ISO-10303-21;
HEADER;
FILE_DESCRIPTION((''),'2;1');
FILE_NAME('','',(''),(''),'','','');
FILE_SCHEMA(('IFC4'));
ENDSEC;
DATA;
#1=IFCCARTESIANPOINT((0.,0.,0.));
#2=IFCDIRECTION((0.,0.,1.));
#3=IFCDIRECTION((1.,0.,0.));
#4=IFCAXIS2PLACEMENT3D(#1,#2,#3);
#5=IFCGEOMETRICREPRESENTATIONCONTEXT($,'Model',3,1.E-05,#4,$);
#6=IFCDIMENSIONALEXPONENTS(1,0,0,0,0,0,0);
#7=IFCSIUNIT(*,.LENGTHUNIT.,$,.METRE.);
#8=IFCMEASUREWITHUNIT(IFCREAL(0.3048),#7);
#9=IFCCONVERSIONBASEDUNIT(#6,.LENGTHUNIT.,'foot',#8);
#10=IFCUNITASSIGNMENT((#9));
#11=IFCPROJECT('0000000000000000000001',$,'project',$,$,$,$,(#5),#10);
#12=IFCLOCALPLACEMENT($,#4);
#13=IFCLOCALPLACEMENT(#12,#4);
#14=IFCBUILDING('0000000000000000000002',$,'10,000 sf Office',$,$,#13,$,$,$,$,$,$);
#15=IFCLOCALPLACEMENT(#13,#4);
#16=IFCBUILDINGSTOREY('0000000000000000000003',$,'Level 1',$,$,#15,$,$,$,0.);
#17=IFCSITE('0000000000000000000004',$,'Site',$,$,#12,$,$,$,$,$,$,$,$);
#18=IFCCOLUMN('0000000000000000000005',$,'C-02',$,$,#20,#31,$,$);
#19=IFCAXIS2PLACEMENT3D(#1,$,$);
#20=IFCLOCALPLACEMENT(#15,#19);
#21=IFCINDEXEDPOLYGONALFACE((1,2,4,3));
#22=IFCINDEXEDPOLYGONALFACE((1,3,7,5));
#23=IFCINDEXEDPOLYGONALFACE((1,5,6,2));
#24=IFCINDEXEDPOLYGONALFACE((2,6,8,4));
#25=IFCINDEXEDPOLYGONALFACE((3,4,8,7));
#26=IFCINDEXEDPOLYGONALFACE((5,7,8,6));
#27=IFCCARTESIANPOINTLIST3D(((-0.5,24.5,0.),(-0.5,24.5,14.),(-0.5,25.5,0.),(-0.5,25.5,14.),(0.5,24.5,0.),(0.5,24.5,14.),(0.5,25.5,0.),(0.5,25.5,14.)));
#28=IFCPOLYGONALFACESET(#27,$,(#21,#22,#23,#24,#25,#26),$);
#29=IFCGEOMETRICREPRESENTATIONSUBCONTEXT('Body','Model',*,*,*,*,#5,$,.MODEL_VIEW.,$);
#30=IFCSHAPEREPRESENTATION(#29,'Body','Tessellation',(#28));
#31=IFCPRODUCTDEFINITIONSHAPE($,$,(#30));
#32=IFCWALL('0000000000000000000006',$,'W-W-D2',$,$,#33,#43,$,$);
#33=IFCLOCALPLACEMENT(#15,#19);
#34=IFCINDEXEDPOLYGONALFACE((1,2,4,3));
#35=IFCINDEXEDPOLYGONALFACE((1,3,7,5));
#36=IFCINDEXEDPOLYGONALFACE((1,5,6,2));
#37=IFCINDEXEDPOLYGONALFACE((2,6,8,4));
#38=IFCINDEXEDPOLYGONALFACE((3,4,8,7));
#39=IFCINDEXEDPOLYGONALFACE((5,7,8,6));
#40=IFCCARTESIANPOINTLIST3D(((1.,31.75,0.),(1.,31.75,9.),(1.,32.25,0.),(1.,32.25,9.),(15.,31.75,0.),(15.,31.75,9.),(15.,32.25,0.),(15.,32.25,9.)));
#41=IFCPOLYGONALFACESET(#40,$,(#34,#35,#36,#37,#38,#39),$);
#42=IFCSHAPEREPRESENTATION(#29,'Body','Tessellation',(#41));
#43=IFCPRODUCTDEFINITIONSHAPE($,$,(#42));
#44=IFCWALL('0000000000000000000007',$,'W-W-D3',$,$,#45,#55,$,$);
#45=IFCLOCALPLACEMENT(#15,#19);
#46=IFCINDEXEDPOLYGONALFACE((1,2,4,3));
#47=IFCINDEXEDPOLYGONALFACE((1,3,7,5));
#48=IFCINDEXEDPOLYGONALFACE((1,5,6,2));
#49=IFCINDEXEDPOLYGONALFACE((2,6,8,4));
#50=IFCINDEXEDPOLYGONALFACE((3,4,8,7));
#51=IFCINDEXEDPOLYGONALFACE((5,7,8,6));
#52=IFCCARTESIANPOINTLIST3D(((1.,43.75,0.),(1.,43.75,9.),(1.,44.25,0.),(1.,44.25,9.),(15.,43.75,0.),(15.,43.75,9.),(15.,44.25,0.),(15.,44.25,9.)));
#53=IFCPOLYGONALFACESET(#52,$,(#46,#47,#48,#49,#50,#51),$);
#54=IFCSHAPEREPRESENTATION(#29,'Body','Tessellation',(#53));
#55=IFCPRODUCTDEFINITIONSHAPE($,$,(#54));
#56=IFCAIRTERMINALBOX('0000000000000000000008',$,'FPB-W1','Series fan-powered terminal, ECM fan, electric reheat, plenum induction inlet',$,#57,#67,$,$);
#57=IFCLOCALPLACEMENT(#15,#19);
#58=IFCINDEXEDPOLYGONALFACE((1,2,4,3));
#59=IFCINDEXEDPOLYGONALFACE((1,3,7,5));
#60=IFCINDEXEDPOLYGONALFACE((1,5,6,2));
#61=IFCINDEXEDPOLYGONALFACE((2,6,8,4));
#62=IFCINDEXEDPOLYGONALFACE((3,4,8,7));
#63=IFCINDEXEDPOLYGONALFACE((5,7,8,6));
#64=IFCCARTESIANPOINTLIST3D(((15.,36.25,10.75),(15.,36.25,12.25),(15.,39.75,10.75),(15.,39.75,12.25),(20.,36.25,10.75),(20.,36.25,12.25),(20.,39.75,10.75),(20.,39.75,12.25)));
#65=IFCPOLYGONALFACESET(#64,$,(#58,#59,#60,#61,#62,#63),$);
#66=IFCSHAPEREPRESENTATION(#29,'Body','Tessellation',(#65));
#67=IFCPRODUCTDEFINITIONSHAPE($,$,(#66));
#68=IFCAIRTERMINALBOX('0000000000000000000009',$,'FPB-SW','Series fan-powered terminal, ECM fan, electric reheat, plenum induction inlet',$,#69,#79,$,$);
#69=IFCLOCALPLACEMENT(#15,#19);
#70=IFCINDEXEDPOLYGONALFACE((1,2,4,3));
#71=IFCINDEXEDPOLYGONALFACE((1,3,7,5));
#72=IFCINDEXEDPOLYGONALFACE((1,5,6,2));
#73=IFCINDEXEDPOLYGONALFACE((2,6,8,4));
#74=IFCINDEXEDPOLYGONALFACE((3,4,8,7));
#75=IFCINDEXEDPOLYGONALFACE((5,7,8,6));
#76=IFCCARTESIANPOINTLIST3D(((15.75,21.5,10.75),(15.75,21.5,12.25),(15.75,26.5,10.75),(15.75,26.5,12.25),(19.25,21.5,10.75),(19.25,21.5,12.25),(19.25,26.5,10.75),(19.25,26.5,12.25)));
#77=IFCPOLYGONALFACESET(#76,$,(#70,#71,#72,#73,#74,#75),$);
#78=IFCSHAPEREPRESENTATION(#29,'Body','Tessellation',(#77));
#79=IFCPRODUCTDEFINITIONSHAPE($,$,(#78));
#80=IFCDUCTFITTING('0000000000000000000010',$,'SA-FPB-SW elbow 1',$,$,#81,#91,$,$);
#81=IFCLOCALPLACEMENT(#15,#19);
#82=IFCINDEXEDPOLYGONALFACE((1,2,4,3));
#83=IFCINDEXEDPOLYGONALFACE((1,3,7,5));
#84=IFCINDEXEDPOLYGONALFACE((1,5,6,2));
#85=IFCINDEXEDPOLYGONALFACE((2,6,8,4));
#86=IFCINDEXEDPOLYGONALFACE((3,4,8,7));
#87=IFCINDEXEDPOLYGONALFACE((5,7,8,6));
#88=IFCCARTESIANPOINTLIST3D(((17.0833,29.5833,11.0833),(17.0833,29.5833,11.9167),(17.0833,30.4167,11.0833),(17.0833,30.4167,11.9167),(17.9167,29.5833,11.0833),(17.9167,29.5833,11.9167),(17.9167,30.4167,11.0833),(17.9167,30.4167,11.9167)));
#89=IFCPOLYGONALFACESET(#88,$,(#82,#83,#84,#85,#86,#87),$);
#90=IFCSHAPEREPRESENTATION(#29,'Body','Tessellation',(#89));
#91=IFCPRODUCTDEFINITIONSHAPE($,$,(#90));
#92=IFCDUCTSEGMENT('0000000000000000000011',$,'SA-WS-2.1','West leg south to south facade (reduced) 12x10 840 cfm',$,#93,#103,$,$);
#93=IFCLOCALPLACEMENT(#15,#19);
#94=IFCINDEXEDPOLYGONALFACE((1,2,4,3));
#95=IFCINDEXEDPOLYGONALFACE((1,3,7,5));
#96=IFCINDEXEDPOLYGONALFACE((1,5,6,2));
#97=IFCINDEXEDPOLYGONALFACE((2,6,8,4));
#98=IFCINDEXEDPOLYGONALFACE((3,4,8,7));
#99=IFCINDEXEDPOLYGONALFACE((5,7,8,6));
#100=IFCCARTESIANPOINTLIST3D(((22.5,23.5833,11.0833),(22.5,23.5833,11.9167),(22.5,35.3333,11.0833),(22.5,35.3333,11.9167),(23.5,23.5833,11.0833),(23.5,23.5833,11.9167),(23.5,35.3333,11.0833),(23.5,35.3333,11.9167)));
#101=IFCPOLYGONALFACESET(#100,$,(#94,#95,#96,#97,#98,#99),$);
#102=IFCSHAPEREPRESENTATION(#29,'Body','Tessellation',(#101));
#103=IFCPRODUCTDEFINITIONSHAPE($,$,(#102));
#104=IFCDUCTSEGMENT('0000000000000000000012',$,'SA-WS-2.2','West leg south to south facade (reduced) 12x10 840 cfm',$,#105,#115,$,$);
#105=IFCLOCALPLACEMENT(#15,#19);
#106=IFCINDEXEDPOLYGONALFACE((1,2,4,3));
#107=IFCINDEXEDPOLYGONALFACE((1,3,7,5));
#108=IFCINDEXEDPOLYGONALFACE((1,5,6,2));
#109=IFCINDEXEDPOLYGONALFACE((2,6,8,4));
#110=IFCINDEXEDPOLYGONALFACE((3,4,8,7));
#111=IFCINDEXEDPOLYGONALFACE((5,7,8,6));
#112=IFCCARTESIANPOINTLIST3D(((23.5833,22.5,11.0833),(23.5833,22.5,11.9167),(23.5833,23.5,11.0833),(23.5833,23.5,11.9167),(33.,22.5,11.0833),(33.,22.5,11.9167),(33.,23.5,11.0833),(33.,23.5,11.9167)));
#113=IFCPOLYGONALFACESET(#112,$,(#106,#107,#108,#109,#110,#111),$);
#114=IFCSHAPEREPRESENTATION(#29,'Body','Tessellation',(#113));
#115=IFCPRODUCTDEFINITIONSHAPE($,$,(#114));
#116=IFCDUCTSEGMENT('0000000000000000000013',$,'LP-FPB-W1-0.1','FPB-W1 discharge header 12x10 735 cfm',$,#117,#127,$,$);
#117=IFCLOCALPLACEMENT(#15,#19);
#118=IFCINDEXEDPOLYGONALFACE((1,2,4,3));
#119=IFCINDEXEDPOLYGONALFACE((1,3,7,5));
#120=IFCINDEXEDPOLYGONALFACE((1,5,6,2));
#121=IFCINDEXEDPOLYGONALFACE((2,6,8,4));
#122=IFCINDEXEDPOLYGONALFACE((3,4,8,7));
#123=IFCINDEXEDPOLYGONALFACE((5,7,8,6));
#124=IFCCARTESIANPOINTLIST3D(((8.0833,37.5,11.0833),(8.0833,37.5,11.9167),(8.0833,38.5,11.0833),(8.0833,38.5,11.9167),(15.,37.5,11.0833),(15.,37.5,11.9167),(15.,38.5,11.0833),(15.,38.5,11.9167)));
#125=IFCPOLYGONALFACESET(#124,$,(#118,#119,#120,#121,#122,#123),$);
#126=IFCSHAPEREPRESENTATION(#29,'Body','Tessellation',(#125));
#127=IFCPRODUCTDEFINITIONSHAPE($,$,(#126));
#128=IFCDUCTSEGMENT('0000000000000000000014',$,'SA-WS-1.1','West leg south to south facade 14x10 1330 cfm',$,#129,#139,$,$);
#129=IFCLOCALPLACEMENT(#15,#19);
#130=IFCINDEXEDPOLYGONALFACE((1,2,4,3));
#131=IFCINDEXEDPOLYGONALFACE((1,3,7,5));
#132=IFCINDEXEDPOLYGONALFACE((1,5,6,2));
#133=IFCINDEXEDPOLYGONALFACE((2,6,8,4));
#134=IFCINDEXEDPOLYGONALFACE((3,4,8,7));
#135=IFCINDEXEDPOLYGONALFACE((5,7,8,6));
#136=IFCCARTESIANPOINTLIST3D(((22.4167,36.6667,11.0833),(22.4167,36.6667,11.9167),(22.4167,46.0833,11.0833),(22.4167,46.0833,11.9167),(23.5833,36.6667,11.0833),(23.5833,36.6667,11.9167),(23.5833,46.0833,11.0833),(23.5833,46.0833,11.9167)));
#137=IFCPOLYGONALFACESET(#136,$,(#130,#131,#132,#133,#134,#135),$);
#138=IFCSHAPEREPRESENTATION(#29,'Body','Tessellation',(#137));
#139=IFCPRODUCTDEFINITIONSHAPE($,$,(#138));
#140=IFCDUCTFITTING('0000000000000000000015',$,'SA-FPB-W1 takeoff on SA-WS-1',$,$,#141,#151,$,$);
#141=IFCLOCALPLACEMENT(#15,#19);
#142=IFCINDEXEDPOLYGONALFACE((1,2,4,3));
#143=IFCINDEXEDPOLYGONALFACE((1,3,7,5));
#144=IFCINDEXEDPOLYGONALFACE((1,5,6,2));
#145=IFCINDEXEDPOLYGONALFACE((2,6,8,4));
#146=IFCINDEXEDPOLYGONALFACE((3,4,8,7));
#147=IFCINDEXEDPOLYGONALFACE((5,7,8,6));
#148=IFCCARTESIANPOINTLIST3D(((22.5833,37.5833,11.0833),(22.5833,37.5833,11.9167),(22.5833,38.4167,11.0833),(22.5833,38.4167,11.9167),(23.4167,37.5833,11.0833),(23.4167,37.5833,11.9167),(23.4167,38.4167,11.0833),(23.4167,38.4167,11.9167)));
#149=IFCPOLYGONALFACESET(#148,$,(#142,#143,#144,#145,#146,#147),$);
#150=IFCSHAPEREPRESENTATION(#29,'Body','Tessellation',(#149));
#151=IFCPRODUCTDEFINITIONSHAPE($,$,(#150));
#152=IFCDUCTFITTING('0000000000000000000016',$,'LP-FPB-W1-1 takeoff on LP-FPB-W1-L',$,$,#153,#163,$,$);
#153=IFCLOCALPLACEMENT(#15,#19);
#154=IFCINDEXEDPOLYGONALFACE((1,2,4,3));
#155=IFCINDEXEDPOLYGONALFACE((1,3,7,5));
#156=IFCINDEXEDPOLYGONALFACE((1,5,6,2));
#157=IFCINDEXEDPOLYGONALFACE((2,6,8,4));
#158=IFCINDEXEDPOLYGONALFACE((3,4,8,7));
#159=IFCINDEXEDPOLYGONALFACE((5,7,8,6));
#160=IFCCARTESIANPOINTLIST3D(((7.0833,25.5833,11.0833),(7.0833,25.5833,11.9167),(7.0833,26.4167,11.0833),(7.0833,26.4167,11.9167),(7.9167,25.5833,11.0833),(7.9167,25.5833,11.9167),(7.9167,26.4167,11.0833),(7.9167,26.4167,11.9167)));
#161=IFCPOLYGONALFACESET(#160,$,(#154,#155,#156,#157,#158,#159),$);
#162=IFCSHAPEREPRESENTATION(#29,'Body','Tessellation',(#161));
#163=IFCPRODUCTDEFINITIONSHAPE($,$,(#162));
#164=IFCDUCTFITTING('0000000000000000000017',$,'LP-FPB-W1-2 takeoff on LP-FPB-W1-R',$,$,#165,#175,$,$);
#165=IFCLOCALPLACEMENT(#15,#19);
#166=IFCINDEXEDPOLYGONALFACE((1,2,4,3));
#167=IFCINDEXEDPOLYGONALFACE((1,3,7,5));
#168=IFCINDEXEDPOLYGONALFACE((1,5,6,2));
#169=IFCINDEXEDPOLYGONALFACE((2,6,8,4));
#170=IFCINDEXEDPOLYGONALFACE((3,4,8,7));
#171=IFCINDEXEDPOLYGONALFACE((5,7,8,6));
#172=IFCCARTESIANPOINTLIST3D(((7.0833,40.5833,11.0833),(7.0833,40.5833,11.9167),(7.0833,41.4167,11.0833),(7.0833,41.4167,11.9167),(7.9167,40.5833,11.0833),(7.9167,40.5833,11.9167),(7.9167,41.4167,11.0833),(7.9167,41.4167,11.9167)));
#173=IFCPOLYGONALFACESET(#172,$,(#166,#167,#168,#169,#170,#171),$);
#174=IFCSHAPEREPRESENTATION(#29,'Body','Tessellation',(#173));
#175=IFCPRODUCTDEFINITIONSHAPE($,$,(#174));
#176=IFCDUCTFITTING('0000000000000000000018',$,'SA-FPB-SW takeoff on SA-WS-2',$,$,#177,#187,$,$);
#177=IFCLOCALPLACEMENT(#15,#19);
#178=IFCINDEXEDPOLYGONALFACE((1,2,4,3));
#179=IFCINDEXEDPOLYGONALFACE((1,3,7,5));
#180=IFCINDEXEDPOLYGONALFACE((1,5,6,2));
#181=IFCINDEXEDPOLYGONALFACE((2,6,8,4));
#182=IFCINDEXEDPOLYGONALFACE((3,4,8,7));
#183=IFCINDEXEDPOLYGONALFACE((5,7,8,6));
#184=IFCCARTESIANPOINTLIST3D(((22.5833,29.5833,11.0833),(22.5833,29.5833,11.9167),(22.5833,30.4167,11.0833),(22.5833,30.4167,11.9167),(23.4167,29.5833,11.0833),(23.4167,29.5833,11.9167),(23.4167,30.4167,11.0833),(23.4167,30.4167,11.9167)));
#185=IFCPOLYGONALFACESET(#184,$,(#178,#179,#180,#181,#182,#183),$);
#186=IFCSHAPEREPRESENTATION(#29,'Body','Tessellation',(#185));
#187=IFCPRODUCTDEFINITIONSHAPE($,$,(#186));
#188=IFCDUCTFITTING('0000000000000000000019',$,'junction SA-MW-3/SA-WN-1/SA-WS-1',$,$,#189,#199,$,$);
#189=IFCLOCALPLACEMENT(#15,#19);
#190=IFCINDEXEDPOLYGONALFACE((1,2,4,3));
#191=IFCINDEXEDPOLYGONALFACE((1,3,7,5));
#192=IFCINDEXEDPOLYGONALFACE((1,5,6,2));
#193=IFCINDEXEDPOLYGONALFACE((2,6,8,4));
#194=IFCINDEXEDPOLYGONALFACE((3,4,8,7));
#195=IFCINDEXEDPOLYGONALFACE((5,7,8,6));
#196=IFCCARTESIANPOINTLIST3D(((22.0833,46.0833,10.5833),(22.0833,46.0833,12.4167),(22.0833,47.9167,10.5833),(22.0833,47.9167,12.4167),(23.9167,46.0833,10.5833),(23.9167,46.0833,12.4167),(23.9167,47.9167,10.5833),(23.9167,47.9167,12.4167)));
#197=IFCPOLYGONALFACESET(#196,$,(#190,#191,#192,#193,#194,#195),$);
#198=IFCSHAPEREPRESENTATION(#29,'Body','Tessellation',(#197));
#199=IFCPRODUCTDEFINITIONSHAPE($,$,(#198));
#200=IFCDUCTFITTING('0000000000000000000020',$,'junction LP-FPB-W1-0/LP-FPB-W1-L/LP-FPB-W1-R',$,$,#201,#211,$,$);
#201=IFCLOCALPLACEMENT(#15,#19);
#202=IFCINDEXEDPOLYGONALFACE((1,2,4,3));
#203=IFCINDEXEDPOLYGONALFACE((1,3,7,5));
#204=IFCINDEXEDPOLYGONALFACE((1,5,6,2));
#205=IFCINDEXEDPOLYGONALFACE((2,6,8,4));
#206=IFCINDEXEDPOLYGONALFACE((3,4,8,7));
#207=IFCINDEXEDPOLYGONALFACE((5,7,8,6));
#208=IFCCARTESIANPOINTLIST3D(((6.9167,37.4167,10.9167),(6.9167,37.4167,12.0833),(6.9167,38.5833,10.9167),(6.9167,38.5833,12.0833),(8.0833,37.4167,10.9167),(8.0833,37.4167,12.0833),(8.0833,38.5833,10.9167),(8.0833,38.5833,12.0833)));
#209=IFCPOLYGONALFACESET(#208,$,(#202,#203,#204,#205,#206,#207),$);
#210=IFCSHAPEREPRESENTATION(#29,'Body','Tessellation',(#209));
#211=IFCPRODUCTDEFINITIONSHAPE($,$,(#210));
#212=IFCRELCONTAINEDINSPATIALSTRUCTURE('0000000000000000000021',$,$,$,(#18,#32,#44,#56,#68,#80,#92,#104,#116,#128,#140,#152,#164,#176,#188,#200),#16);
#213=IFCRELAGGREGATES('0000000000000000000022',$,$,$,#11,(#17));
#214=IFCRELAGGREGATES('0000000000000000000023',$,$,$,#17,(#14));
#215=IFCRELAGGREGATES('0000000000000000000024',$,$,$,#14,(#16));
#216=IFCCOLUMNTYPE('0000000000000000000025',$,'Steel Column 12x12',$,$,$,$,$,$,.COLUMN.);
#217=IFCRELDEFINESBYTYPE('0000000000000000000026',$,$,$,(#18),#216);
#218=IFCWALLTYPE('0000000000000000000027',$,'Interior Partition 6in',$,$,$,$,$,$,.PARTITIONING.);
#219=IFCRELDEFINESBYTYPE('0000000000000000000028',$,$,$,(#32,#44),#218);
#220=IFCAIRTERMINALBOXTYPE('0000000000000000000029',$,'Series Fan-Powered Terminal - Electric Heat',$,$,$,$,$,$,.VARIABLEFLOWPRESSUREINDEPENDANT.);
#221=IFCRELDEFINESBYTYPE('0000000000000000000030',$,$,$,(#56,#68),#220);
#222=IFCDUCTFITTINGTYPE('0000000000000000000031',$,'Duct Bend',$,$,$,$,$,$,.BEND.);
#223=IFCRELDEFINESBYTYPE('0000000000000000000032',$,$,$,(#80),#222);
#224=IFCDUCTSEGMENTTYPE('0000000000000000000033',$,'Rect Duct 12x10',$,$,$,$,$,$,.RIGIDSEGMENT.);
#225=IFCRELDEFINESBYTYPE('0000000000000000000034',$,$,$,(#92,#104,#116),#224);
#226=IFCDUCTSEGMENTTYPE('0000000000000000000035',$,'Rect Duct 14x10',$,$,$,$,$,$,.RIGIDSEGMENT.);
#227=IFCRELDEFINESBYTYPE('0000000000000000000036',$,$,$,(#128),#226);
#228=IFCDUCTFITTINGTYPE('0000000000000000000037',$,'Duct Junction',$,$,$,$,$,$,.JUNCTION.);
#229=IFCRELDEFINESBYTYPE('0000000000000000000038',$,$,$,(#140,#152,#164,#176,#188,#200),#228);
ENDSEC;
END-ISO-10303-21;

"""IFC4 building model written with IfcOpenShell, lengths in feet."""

from ifc_helpers import new_model, entity, si_unit, converted_unit, frame, origin_with_axes, place, context, subcontext, project, spatial, rectangle, extrude, type_object, element, save


model = new_model("IFC4")

# Units and contexts
model_context = context("Model", 3, precision=1e-05, world=origin_with_axes())
body_context = subcontext(model_context, "Body", "Model", "MODEL_VIEW")
ifc_project = project(units=[converted_unit("LENGTHUNIT", "foot", entity("IfcReal", 0.3048), si_unit("LENGTHUNIT", "METRE"), dimensions=[1, 0, 0, 0, 0, 0, 0])], contexts=[model_context])

# Site, building, storey
site_placement = place(None, origin_with_axes())
site = spatial("IfcSite", under=ifc_project, at=site_placement, Name="Site")
building_placement = place(site_placement, origin_with_axes())
building = spatial("IfcBuilding", under=site, at=building_placement, Name="10,000 sf Office")
storey_placement = place(building_placement, origin_with_axes())
storey = spatial("IfcBuildingStorey", under=building, at=storey_placement, Name="Level 1", Elevation=0.0)

# Column
column_type = type_object("IfcColumnType", Name="Steel Column 12x12", PredefinedType="COLUMN")
column_placement = place(storey_placement, frame((0.0, 25.0, 0.0), z_axis=(0.0, 0.0, 1.0), x_axis=(1.0, 0.0, 0.0)))
element("IfcColumn", 1, at=column_placement, inside=storey, type_object=column_type, Name="C-02", context=body_context, shape_type="SweptSolid", body=[
    extrude(rectangle(XDim=1.0, YDim=1.0), None, (0.0, 0.0, 1.0), 14.0),
])

# Walls
wall_type = type_object("IfcWallType", Name="Interior Partition 6in", PredefinedType="PARTITIONING")
for number, where, z_axis, x_axis, name in (
    (2, (8.0, 32.0, 0.0), (0.0, 0.0, 1.0), (1.0, 0.0, 0.0), "W-W-D2"),
    (3, (8.0, 44.0, 0.0), (0.0, 0.0, 1.0), (1.0, 0.0, 0.0), "W-W-D3"),
):
    element("IfcWall", number, at=place(storey_placement, frame(where, z_axis=z_axis, x_axis=x_axis)), inside=storey, type_object=wall_type, Name=name, context=body_context, shape_type="SweptSolid", body=[
        extrude(rectangle(XDim=14.0, YDim=0.5), None, (0.0, 0.0, 1.0), 9.0),
    ])

# Air terminal boxes
air_terminal_box_type = type_object("IfcAirTerminalBoxType", Name="Series Fan-Powered Terminal - Electric Heat", PredefinedType="VARIABLEFLOWPRESSUREINDEPENDANT")
for number, where, z_axis, x_axis, name in (
    (4, (17.5, 38.0, 10.75), (0.0, 0.0, 1.0), (-1.0, 0.0, 0.0), "FPB-W1"),
    (5, (17.5, 24.0, 10.75), (0.0, 0.0, 1.0), (0.0, -1.0, 0.0), "FPB-SW"),
):
    element("IfcAirTerminalBox", number, at=place(storey_placement, frame(where, z_axis=z_axis, x_axis=x_axis)), inside=storey, type_object=air_terminal_box_type, Name=name, Description="Series fan-powered terminal, ECM fan, electric reheat, plenum induction inlet", context=body_context, shape_type="SweptSolid", body=[
        extrude(rectangle(XDim=5.0, YDim=3.5), None, (0.0, 0.0, 1.0), 1.5),
    ])

# Duct fitting
duct_fitting_type_1 = type_object("IfcDuctFittingType", Name="Duct Bend", PredefinedType="BEND")
duct_fitting_1_placement = place(storey_placement, frame((17.5, 30.0, 11.0833), z_axis=(0.0, 0.0, 1.0), x_axis=(1.0, 0.0, 0.0)))
element("IfcDuctFitting", 6, at=duct_fitting_1_placement, inside=storey, type_object=duct_fitting_type_1, Name="SA-FPB-SW elbow 1", context=body_context, shape_type="SweptSolid", body=[
    extrude(rectangle(XDim=0.8333, YDim=0.8333), None, (0.0, 0.0, 1.0), 0.8333),
])

# Duct segments
duct_segment_type_1 = type_object("IfcDuctSegmentType", Name="Rect Duct 12x10", PredefinedType="RIGIDSEGMENT")
duct_segment_1_placement = place(storey_placement, frame((23.0, 35.3333, 11.5), z_axis=(0.0, -1.0, 0.0), x_axis=(1.0, 0.0, 0.0)))
element("IfcDuctSegment", 7, at=duct_segment_1_placement, inside=storey, type_object=duct_segment_type_1, Name="SA-WS-2.1", Description="West leg south to south facade (reduced) 12x10 840 cfm", context=body_context, shape_type="SweptSolid", body=[
    extrude(rectangle(XDim=1.0, YDim=0.8333), None, (0.0, 0.0, 1.0), 11.75),
])
duct_segment_2_placement = place(storey_placement, frame((23.5833, 23.0, 11.5), z_axis=(1.0, 0.0, 0.0), x_axis=(0.0, 1.0, 0.0)))
element("IfcDuctSegment", 8, at=duct_segment_2_placement, inside=storey, type_object=duct_segment_type_1, Name="SA-WS-2.2", Description="West leg south to south facade (reduced) 12x10 840 cfm", context=body_context, shape_type="SweptSolid", body=[
    extrude(rectangle(XDim=1.0, YDim=0.8333), None, (0.0, 0.0, 1.0), 9.4167),
])
duct_segment_3_placement = place(storey_placement, frame((15.0, 38.0, 11.5), z_axis=(-1.0, 0.0, 0.0), x_axis=(0.0, -1.0, 0.0)))
element("IfcDuctSegment", 9, at=duct_segment_3_placement, inside=storey, type_object=duct_segment_type_1, Name="LP-FPB-W1-0.1", Description="FPB-W1 discharge header 12x10 735 cfm", context=body_context, shape_type="SweptSolid", body=[
    extrude(rectangle(XDim=1.0, YDim=0.8333), None, (0.0, 0.0, 1.0), 6.9167),
])
duct_segment_type_2 = type_object("IfcDuctSegmentType", Name="Rect Duct 14x10", PredefinedType="RIGIDSEGMENT")
duct_segment_4_placement = place(storey_placement, frame((23.0, 46.0833, 11.5), z_axis=(0.0, -1.0, 0.0), x_axis=(1.0, 0.0, 0.0)))
element("IfcDuctSegment", 10, at=duct_segment_4_placement, inside=storey, type_object=duct_segment_type_2, Name="SA-WS-1.1", Description="West leg south to south facade 14x10 1330 cfm", context=body_context, shape_type="SweptSolid", body=[
    extrude(rectangle(XDim=1.1667, YDim=0.8333), None, (0.0, 0.0, 1.0), 9.4167),
])

# Duct fittings
duct_fitting_type_2 = type_object("IfcDuctFittingType", Name="Duct Junction", PredefinedType="JUNCTION")
for number, where, z_axis, x_axis, name in (
    (11, (23.0, 38.0, 11.0833), (0.0, 0.0, 1.0), (1.0, 0.0, 0.0), "SA-FPB-W1 takeoff on SA-WS-1"),
    (12, (7.5, 26.0, 11.0833), (0.0, 0.0, 1.0), (1.0, 0.0, 0.0), "LP-FPB-W1-1 takeoff on LP-FPB-W1-L"),
    (13, (7.5, 41.0, 11.0833), (0.0, 0.0, 1.0), (1.0, 0.0, 0.0), "LP-FPB-W1-2 takeoff on LP-FPB-W1-R"),
    (14, (23.0, 30.0, 11.0833), (0.0, 0.0, 1.0), (1.0, 0.0, 0.0), "SA-FPB-SW takeoff on SA-WS-2"),
):
    element("IfcDuctFitting", number, at=place(storey_placement, frame(where, z_axis=z_axis, x_axis=x_axis)), inside=storey, type_object=duct_fitting_type_2, Name=name, context=body_context, shape_type="SweptSolid", body=[
        extrude(rectangle(XDim=0.8333, YDim=0.8333), None, (0.0, 0.0, 1.0), 0.8333),
    ])
duct_fitting_2_placement = place(storey_placement, frame((23.0, 47.0, 10.5833), z_axis=(0.0, 0.0, 1.0), x_axis=(1.0, 0.0, 0.0)))
element("IfcDuctFitting", 15, at=duct_fitting_2_placement, inside=storey, type_object=duct_fitting_type_2, Name="junction SA-MW-3/SA-WN-1/SA-WS-1", context=body_context, shape_type="SweptSolid", body=[
    extrude(rectangle(XDim=1.8333, YDim=1.8333), None, (0.0, 0.0, 1.0), 1.8333),
])
duct_fitting_3_placement = place(storey_placement, frame((7.5, 38.0, 10.9167), z_axis=(0.0, 0.0, 1.0), x_axis=(1.0, 0.0, 0.0)))
element("IfcDuctFitting", 16, at=duct_fitting_3_placement, inside=storey, type_object=duct_fitting_type_2, Name="junction LP-FPB-W1-0/LP-FPB-W1-L/LP-FPB-W1-R", context=body_context, shape_type="SweptSolid", body=[
    extrude(rectangle(XDim=1.1667, YDim=1.1667), None, (0.0, 0.0, 1.0), 1.1667),
])

save(model, "model.ifc")
